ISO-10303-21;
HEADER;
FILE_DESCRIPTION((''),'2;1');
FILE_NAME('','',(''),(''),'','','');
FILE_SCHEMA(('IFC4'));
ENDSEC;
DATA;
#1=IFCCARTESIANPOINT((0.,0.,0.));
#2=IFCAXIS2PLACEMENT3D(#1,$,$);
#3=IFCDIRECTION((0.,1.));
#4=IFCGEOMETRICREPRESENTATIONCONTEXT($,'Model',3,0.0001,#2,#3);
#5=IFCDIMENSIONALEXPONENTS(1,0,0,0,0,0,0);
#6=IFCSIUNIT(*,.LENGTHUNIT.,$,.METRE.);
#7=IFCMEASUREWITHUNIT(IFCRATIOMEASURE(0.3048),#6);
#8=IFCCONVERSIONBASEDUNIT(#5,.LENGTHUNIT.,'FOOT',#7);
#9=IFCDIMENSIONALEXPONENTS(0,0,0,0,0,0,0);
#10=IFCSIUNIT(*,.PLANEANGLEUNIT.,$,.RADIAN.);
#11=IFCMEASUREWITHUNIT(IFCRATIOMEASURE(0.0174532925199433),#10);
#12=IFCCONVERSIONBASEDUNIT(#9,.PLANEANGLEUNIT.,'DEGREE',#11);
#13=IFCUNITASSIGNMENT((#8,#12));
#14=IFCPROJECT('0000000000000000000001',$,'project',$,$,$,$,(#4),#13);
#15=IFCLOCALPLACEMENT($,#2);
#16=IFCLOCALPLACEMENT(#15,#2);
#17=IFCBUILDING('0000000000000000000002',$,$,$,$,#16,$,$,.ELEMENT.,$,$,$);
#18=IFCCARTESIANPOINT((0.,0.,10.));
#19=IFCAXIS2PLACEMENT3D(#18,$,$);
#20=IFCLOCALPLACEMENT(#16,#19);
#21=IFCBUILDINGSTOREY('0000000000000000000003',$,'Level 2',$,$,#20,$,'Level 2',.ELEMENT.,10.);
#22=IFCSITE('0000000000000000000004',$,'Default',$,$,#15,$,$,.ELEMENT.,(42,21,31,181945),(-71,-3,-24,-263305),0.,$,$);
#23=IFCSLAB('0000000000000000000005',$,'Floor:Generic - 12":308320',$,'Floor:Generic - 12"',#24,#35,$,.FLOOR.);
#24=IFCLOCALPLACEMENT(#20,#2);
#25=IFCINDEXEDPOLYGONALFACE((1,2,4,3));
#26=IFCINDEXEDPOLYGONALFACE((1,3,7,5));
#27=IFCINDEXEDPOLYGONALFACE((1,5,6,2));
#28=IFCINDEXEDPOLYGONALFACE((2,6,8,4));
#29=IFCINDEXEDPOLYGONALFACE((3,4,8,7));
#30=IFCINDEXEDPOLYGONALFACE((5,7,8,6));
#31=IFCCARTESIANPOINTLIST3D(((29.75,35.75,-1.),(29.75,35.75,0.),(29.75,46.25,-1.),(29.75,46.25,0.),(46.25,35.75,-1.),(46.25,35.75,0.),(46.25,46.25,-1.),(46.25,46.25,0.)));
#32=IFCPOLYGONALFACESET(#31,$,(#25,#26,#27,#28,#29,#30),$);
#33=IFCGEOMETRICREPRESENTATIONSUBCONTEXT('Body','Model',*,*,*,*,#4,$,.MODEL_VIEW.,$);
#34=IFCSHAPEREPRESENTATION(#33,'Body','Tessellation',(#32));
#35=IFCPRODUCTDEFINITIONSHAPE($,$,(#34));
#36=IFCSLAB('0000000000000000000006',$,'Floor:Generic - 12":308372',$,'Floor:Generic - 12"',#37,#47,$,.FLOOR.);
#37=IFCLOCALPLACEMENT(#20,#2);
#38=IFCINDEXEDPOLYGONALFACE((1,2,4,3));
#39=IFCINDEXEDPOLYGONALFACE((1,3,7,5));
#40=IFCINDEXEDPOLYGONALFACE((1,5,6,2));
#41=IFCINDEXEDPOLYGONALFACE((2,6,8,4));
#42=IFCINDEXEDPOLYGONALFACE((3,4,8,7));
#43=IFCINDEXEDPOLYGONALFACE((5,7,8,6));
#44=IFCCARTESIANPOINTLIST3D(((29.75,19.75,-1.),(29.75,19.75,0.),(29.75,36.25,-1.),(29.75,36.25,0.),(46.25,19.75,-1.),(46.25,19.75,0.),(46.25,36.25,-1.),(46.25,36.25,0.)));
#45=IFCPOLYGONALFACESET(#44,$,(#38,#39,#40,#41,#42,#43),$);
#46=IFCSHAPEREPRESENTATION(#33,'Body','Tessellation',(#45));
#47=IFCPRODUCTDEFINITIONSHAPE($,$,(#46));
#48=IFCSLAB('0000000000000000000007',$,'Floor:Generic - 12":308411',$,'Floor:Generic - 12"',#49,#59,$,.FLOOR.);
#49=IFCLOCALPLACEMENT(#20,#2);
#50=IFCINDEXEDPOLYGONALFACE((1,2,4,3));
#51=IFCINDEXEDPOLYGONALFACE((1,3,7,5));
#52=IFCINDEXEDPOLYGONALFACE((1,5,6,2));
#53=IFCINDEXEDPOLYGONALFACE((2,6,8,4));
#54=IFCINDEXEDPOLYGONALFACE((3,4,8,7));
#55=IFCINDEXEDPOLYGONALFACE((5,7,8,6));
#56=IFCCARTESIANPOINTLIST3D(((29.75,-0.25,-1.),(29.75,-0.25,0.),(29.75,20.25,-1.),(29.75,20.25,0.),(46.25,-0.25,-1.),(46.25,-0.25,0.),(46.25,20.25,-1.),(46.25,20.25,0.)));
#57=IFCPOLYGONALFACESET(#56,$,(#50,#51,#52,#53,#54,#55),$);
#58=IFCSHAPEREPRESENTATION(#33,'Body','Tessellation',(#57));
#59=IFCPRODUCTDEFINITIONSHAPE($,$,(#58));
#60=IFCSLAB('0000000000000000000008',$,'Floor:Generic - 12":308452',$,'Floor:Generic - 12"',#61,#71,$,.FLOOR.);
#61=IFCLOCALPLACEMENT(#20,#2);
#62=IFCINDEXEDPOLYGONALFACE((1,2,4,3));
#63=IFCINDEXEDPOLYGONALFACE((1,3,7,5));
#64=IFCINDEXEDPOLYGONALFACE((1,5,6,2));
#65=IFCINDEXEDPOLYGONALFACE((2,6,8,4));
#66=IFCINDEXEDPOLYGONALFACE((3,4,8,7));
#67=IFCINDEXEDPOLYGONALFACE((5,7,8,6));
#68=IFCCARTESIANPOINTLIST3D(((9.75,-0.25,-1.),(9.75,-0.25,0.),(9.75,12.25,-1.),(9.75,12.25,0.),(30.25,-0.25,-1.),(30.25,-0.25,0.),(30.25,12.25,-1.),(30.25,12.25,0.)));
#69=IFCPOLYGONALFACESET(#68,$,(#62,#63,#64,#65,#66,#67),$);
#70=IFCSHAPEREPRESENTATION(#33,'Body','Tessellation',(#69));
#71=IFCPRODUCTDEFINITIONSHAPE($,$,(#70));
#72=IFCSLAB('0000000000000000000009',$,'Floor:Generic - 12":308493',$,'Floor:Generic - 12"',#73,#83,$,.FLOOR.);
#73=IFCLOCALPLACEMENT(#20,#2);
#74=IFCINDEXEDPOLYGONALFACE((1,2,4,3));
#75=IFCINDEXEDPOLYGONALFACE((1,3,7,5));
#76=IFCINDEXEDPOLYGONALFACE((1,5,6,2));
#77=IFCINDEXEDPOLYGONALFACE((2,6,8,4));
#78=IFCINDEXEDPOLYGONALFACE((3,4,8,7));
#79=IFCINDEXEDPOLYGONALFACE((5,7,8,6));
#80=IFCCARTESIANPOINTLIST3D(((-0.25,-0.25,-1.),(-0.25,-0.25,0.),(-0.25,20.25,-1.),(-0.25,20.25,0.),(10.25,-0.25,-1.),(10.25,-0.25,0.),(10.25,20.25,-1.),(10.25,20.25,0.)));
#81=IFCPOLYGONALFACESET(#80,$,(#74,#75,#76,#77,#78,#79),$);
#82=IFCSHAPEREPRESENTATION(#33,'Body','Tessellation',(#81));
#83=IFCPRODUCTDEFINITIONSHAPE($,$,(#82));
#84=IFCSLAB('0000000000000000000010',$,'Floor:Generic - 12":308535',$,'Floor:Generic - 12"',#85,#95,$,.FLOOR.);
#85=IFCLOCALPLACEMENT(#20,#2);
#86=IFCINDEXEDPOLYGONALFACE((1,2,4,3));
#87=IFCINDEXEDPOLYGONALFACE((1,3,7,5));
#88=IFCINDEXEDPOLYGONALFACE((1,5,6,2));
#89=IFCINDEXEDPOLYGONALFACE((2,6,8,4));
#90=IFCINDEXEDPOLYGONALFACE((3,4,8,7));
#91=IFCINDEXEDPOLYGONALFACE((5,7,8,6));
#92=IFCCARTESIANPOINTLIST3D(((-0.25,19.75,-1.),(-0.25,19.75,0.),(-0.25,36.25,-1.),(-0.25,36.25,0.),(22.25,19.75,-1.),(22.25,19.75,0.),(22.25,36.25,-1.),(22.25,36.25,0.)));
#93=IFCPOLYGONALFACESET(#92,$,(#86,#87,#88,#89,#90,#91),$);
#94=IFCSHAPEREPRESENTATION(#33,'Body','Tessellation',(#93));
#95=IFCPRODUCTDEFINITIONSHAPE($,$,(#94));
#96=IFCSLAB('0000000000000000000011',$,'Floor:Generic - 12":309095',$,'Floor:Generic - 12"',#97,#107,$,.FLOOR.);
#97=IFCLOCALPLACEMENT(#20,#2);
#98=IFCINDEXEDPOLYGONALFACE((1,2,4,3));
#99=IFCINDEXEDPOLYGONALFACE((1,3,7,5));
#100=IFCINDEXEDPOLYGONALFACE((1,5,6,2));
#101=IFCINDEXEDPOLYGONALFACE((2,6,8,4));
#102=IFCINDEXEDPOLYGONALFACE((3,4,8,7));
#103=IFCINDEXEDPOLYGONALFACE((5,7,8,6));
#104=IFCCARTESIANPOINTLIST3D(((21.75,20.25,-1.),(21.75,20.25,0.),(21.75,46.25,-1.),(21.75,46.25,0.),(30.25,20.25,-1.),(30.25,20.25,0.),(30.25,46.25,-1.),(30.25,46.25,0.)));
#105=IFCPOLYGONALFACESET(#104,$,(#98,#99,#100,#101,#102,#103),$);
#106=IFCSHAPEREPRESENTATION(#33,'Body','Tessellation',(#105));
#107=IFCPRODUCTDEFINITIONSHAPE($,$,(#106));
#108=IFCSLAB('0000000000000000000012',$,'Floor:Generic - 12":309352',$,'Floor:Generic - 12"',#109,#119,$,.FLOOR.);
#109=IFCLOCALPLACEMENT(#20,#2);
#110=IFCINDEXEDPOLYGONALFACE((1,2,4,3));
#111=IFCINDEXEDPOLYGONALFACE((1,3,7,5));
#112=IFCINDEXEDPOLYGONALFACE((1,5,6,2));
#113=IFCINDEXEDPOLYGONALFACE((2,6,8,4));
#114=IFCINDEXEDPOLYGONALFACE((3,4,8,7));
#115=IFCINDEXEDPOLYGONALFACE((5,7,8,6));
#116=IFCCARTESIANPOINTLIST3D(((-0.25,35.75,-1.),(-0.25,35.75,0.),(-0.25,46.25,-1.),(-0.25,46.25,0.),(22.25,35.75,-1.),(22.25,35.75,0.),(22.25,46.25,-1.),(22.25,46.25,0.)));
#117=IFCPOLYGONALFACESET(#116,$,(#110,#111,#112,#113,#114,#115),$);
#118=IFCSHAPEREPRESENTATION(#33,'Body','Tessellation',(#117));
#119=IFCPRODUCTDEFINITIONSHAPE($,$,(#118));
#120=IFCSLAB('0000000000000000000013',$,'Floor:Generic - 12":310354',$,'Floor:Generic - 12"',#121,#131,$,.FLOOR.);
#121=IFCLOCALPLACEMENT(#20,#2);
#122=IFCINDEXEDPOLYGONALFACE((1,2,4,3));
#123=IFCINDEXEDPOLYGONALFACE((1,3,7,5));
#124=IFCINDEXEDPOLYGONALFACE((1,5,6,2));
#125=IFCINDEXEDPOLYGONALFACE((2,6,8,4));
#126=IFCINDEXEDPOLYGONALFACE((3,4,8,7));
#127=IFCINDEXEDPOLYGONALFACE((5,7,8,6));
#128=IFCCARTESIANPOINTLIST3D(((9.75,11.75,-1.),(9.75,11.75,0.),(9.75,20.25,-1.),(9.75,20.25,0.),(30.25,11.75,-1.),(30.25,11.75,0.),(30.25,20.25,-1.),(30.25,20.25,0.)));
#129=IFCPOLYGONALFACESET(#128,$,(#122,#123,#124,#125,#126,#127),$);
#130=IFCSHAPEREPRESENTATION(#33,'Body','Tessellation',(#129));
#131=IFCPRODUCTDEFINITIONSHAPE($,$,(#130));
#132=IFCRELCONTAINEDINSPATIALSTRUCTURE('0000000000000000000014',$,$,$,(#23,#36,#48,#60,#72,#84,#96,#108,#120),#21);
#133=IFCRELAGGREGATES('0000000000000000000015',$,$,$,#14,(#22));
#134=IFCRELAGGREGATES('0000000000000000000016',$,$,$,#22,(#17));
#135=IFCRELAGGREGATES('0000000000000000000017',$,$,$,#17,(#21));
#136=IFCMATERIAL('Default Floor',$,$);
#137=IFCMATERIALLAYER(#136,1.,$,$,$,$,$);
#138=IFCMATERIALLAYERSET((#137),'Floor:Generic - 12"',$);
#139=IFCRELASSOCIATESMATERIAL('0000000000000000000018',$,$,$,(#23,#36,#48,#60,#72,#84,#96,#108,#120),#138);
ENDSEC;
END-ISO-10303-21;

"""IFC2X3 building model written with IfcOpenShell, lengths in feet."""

from ifc_helpers import new_model, entity, si_unit, converted_unit, direction, frame, frame_2d, origin, place, context, subcontext, project, spatial, rectangle, extrude, material, layer, layer_set, layer_usage, element, save


model = new_model("IFC2X3")

# Units and contexts
model_context = context("Model", 3, precision=0.0001, world=origin(), true_north=direction((0.0, 1.0)))
body_context = subcontext(model_context, "Body", "Model", "MODEL_VIEW")
ifc_project = project(units=[converted_unit("LENGTHUNIT", "FOOT", entity("IfcRatioMeasure", 0.3048), si_unit("LENGTHUNIT", "METRE"), dimensions=[1, 0, 0, 0, 0, 0, 0]), converted_unit("PLANEANGLEUNIT", "DEGREE", entity("IfcRatioMeasure", 0.0174532925199433), si_unit("PLANEANGLEUNIT", "RADIAN"), dimensions=[0, 0, 0, 0, 0, 0, 0])], contexts=[model_context])

# Site, building, storey
site_placement = place(None, origin())
site = spatial("IfcSite", under=ifc_project, at=site_placement, Name="Default", CompositionType="ELEMENT", RefLatitude=(42, 21, 31, 181945), RefLongitude=(-71, -3, -24, -263305), RefElevation=0.0)
building_placement = place(site_placement, origin())
building = spatial("IfcBuilding", under=site, at=building_placement, CompositionType="ELEMENT")
storey_placement = place(building_placement, frame((0.0, 0.0, 10.0)))
storey = spatial("IfcBuildingStorey", under=building, at=storey_placement, Name="Level 2", LongName="Level 2", CompositionType="ELEMENT", Elevation=10.0)

# Slabs
ifc_material = material(Name="Default Floor")
ifc_layer = layer(ifc_material, 1.0)
ifc_layer_set = layer_set([ifc_layer], Name="Floor:Generic - 12\"")
ifc_layer_usage_1 = layer_usage(ifc_layer_set, "AXIS3", "POSITIVE", 0.0)
slab_1_placement = place(storey_placement, origin())
element("IfcSlab", 1, at=slab_1_placement, inside=storey, material=ifc_layer_usage_1, Name="Floor:Generic - 12\":308320", ObjectType="Floor:Generic - 12\"", PredefinedType="FLOOR", context=body_context, shape_type="SweptSolid", body=[
    extrude(rectangle(XDim=10.5, YDim=16.5, at=frame_2d((0.0, 0.0), x_axis=(1.0, 0.0))), frame((38.0, 41.0, 0.0), z_axis=(0.0, 0.0, -1.0), x_axis=(0.0, 1.0, 0.0)), (0.0, 0.0, 1.0), 1.0),
])
ifc_layer_usage_2 = layer_usage(ifc_layer_set, "AXIS3", "POSITIVE", 0.0)
slab_2_placement = place(storey_placement, origin())
element("IfcSlab", 2, at=slab_2_placement, inside=storey, material=ifc_layer_usage_2, Name="Floor:Generic - 12\":308372", ObjectType="Floor:Generic - 12\"", PredefinedType="FLOOR", context=body_context, shape_type="SweptSolid", body=[
    extrude(rectangle(XDim=16.5, YDim=16.5, at=frame_2d((0.0, 0.0), x_axis=(1.0, 0.0))), frame((38.0, 28.0, 0.0), z_axis=(0.0, 0.0, -1.0), x_axis=(0.0, 1.0, 0.0)), (0.0, 0.0, 1.0), 1.0),
])
ifc_layer_usage_3 = layer_usage(ifc_layer_set, "AXIS3", "POSITIVE", 0.0)
slab_3_placement = place(storey_placement, origin())
element("IfcSlab", 3, at=slab_3_placement, inside=storey, material=ifc_layer_usage_3, Name="Floor:Generic - 12\":308411", ObjectType="Floor:Generic - 12\"", PredefinedType="FLOOR", context=body_context, shape_type="SweptSolid", body=[
    extrude(rectangle(XDim=20.5, YDim=16.5, at=frame_2d((0.0, 0.0), x_axis=(1.0, 0.0))), frame((38.0, 10.0, 0.0), z_axis=(0.0, 0.0, -1.0), x_axis=(0.0, 1.0, 0.0)), (0.0, 0.0, 1.0), 1.0),
])
ifc_layer_usage_4 = layer_usage(ifc_layer_set, "AXIS3", "POSITIVE", 0.0)
slab_4_placement = place(storey_placement, origin())
element("IfcSlab", 4, at=slab_4_placement, inside=storey, material=ifc_layer_usage_4, Name="Floor:Generic - 12\":308452", ObjectType="Floor:Generic - 12\"", PredefinedType="FLOOR", context=body_context, shape_type="SweptSolid", body=[
    extrude(rectangle(XDim=12.5, YDim=20.5, at=frame_2d((0.0, 0.0), x_axis=(1.0, 0.0))), frame((20.0, 6.0, 0.0), z_axis=(0.0, 0.0, -1.0), x_axis=(0.0, 1.0, 0.0)), (0.0, 0.0, 1.0), 1.0),
])
ifc_layer_usage_5 = layer_usage(ifc_layer_set, "AXIS3", "POSITIVE", 0.0)
slab_5_placement = place(storey_placement, origin())
element("IfcSlab", 5, at=slab_5_placement, inside=storey, material=ifc_layer_usage_5, Name="Floor:Generic - 12\":308493", ObjectType="Floor:Generic - 12\"", PredefinedType="FLOOR", context=body_context, shape_type="SweptSolid", body=[
    extrude(rectangle(XDim=20.5, YDim=10.5, at=frame_2d((0.0, 0.0), x_axis=(1.0, 0.0))), frame((5.0, 10.0, 0.0), z_axis=(0.0, 0.0, -1.0), x_axis=(0.0, 1.0, 0.0)), (0.0, 0.0, 1.0), 1.0),
])
ifc_layer_usage_6 = layer_usage(ifc_layer_set, "AXIS3", "POSITIVE", 0.0)
slab_6_placement = place(storey_placement, origin())
element("IfcSlab", 6, at=slab_6_placement, inside=storey, material=ifc_layer_usage_6, Name="Floor:Generic - 12\":308535", ObjectType="Floor:Generic - 12\"", PredefinedType="FLOOR", context=body_context, shape_type="SweptSolid", body=[
    extrude(rectangle(XDim=16.5, YDim=22.5, at=frame_2d((0.0, 0.0), x_axis=(1.0, 0.0))), frame((11.0, 28.0, 0.0), z_axis=(0.0, 0.0, -1.0), x_axis=(0.0, 1.0, 0.0)), (0.0, 0.0, 1.0), 1.0),
])
ifc_layer_usage_7 = layer_usage(ifc_layer_set, "AXIS3", "POSITIVE", 0.0)
slab_7_placement = place(storey_placement, origin())
element("IfcSlab", 7, at=slab_7_placement, inside=storey, material=ifc_layer_usage_7, Name="Floor:Generic - 12\":309095", ObjectType="Floor:Generic - 12\"", PredefinedType="FLOOR", context=body_context, shape_type="SweptSolid", body=[
    extrude(rectangle(XDim=26.0, YDim=8.5, at=frame_2d((0.0, 0.0), x_axis=(1.0, 0.0))), frame((26.0, 33.25, 0.0), z_axis=(0.0, 0.0, -1.0), x_axis=(0.0, 1.0, 0.0)), (0.0, 0.0, 1.0), 1.0),
])
ifc_layer_usage_8 = layer_usage(ifc_layer_set, "AXIS3", "POSITIVE", 0.0)
slab_8_placement = place(storey_placement, origin())
element("IfcSlab", 8, at=slab_8_placement, inside=storey, material=ifc_layer_usage_8, Name="Floor:Generic - 12\":309352", ObjectType="Floor:Generic - 12\"", PredefinedType="FLOOR", context=body_context, shape_type="SweptSolid", body=[
    extrude(rectangle(XDim=10.5, YDim=22.5, at=frame_2d((0.0, 0.0), x_axis=(1.0, 0.0))), frame((11.0, 41.0, 0.0), z_axis=(0.0, 0.0, -1.0), x_axis=(0.0, 1.0, 0.0)), (0.0, 0.0, 1.0), 1.0),
])
ifc_layer_usage_9 = layer_usage(ifc_layer_set, "AXIS3", "POSITIVE", 0.0)
slab_9_placement = place(storey_placement, origin())
element("IfcSlab", 9, at=slab_9_placement, inside=storey, material=ifc_layer_usage_9, Name="Floor:Generic - 12\":310354", ObjectType="Floor:Generic - 12\"", PredefinedType="FLOOR", context=body_context, shape_type="SweptSolid", body=[
    extrude(rectangle(XDim=8.5, YDim=20.5, at=frame_2d((0.0, 0.0), x_axis=(1.0, 0.0))), frame((20.0, 16.0, 0.0), z_axis=(0.0, 0.0, -1.0), x_axis=(0.0, 1.0, 0.0)), (0.0, 0.0, 1.0), 1.0),
])

save(model, "model.ifc")
